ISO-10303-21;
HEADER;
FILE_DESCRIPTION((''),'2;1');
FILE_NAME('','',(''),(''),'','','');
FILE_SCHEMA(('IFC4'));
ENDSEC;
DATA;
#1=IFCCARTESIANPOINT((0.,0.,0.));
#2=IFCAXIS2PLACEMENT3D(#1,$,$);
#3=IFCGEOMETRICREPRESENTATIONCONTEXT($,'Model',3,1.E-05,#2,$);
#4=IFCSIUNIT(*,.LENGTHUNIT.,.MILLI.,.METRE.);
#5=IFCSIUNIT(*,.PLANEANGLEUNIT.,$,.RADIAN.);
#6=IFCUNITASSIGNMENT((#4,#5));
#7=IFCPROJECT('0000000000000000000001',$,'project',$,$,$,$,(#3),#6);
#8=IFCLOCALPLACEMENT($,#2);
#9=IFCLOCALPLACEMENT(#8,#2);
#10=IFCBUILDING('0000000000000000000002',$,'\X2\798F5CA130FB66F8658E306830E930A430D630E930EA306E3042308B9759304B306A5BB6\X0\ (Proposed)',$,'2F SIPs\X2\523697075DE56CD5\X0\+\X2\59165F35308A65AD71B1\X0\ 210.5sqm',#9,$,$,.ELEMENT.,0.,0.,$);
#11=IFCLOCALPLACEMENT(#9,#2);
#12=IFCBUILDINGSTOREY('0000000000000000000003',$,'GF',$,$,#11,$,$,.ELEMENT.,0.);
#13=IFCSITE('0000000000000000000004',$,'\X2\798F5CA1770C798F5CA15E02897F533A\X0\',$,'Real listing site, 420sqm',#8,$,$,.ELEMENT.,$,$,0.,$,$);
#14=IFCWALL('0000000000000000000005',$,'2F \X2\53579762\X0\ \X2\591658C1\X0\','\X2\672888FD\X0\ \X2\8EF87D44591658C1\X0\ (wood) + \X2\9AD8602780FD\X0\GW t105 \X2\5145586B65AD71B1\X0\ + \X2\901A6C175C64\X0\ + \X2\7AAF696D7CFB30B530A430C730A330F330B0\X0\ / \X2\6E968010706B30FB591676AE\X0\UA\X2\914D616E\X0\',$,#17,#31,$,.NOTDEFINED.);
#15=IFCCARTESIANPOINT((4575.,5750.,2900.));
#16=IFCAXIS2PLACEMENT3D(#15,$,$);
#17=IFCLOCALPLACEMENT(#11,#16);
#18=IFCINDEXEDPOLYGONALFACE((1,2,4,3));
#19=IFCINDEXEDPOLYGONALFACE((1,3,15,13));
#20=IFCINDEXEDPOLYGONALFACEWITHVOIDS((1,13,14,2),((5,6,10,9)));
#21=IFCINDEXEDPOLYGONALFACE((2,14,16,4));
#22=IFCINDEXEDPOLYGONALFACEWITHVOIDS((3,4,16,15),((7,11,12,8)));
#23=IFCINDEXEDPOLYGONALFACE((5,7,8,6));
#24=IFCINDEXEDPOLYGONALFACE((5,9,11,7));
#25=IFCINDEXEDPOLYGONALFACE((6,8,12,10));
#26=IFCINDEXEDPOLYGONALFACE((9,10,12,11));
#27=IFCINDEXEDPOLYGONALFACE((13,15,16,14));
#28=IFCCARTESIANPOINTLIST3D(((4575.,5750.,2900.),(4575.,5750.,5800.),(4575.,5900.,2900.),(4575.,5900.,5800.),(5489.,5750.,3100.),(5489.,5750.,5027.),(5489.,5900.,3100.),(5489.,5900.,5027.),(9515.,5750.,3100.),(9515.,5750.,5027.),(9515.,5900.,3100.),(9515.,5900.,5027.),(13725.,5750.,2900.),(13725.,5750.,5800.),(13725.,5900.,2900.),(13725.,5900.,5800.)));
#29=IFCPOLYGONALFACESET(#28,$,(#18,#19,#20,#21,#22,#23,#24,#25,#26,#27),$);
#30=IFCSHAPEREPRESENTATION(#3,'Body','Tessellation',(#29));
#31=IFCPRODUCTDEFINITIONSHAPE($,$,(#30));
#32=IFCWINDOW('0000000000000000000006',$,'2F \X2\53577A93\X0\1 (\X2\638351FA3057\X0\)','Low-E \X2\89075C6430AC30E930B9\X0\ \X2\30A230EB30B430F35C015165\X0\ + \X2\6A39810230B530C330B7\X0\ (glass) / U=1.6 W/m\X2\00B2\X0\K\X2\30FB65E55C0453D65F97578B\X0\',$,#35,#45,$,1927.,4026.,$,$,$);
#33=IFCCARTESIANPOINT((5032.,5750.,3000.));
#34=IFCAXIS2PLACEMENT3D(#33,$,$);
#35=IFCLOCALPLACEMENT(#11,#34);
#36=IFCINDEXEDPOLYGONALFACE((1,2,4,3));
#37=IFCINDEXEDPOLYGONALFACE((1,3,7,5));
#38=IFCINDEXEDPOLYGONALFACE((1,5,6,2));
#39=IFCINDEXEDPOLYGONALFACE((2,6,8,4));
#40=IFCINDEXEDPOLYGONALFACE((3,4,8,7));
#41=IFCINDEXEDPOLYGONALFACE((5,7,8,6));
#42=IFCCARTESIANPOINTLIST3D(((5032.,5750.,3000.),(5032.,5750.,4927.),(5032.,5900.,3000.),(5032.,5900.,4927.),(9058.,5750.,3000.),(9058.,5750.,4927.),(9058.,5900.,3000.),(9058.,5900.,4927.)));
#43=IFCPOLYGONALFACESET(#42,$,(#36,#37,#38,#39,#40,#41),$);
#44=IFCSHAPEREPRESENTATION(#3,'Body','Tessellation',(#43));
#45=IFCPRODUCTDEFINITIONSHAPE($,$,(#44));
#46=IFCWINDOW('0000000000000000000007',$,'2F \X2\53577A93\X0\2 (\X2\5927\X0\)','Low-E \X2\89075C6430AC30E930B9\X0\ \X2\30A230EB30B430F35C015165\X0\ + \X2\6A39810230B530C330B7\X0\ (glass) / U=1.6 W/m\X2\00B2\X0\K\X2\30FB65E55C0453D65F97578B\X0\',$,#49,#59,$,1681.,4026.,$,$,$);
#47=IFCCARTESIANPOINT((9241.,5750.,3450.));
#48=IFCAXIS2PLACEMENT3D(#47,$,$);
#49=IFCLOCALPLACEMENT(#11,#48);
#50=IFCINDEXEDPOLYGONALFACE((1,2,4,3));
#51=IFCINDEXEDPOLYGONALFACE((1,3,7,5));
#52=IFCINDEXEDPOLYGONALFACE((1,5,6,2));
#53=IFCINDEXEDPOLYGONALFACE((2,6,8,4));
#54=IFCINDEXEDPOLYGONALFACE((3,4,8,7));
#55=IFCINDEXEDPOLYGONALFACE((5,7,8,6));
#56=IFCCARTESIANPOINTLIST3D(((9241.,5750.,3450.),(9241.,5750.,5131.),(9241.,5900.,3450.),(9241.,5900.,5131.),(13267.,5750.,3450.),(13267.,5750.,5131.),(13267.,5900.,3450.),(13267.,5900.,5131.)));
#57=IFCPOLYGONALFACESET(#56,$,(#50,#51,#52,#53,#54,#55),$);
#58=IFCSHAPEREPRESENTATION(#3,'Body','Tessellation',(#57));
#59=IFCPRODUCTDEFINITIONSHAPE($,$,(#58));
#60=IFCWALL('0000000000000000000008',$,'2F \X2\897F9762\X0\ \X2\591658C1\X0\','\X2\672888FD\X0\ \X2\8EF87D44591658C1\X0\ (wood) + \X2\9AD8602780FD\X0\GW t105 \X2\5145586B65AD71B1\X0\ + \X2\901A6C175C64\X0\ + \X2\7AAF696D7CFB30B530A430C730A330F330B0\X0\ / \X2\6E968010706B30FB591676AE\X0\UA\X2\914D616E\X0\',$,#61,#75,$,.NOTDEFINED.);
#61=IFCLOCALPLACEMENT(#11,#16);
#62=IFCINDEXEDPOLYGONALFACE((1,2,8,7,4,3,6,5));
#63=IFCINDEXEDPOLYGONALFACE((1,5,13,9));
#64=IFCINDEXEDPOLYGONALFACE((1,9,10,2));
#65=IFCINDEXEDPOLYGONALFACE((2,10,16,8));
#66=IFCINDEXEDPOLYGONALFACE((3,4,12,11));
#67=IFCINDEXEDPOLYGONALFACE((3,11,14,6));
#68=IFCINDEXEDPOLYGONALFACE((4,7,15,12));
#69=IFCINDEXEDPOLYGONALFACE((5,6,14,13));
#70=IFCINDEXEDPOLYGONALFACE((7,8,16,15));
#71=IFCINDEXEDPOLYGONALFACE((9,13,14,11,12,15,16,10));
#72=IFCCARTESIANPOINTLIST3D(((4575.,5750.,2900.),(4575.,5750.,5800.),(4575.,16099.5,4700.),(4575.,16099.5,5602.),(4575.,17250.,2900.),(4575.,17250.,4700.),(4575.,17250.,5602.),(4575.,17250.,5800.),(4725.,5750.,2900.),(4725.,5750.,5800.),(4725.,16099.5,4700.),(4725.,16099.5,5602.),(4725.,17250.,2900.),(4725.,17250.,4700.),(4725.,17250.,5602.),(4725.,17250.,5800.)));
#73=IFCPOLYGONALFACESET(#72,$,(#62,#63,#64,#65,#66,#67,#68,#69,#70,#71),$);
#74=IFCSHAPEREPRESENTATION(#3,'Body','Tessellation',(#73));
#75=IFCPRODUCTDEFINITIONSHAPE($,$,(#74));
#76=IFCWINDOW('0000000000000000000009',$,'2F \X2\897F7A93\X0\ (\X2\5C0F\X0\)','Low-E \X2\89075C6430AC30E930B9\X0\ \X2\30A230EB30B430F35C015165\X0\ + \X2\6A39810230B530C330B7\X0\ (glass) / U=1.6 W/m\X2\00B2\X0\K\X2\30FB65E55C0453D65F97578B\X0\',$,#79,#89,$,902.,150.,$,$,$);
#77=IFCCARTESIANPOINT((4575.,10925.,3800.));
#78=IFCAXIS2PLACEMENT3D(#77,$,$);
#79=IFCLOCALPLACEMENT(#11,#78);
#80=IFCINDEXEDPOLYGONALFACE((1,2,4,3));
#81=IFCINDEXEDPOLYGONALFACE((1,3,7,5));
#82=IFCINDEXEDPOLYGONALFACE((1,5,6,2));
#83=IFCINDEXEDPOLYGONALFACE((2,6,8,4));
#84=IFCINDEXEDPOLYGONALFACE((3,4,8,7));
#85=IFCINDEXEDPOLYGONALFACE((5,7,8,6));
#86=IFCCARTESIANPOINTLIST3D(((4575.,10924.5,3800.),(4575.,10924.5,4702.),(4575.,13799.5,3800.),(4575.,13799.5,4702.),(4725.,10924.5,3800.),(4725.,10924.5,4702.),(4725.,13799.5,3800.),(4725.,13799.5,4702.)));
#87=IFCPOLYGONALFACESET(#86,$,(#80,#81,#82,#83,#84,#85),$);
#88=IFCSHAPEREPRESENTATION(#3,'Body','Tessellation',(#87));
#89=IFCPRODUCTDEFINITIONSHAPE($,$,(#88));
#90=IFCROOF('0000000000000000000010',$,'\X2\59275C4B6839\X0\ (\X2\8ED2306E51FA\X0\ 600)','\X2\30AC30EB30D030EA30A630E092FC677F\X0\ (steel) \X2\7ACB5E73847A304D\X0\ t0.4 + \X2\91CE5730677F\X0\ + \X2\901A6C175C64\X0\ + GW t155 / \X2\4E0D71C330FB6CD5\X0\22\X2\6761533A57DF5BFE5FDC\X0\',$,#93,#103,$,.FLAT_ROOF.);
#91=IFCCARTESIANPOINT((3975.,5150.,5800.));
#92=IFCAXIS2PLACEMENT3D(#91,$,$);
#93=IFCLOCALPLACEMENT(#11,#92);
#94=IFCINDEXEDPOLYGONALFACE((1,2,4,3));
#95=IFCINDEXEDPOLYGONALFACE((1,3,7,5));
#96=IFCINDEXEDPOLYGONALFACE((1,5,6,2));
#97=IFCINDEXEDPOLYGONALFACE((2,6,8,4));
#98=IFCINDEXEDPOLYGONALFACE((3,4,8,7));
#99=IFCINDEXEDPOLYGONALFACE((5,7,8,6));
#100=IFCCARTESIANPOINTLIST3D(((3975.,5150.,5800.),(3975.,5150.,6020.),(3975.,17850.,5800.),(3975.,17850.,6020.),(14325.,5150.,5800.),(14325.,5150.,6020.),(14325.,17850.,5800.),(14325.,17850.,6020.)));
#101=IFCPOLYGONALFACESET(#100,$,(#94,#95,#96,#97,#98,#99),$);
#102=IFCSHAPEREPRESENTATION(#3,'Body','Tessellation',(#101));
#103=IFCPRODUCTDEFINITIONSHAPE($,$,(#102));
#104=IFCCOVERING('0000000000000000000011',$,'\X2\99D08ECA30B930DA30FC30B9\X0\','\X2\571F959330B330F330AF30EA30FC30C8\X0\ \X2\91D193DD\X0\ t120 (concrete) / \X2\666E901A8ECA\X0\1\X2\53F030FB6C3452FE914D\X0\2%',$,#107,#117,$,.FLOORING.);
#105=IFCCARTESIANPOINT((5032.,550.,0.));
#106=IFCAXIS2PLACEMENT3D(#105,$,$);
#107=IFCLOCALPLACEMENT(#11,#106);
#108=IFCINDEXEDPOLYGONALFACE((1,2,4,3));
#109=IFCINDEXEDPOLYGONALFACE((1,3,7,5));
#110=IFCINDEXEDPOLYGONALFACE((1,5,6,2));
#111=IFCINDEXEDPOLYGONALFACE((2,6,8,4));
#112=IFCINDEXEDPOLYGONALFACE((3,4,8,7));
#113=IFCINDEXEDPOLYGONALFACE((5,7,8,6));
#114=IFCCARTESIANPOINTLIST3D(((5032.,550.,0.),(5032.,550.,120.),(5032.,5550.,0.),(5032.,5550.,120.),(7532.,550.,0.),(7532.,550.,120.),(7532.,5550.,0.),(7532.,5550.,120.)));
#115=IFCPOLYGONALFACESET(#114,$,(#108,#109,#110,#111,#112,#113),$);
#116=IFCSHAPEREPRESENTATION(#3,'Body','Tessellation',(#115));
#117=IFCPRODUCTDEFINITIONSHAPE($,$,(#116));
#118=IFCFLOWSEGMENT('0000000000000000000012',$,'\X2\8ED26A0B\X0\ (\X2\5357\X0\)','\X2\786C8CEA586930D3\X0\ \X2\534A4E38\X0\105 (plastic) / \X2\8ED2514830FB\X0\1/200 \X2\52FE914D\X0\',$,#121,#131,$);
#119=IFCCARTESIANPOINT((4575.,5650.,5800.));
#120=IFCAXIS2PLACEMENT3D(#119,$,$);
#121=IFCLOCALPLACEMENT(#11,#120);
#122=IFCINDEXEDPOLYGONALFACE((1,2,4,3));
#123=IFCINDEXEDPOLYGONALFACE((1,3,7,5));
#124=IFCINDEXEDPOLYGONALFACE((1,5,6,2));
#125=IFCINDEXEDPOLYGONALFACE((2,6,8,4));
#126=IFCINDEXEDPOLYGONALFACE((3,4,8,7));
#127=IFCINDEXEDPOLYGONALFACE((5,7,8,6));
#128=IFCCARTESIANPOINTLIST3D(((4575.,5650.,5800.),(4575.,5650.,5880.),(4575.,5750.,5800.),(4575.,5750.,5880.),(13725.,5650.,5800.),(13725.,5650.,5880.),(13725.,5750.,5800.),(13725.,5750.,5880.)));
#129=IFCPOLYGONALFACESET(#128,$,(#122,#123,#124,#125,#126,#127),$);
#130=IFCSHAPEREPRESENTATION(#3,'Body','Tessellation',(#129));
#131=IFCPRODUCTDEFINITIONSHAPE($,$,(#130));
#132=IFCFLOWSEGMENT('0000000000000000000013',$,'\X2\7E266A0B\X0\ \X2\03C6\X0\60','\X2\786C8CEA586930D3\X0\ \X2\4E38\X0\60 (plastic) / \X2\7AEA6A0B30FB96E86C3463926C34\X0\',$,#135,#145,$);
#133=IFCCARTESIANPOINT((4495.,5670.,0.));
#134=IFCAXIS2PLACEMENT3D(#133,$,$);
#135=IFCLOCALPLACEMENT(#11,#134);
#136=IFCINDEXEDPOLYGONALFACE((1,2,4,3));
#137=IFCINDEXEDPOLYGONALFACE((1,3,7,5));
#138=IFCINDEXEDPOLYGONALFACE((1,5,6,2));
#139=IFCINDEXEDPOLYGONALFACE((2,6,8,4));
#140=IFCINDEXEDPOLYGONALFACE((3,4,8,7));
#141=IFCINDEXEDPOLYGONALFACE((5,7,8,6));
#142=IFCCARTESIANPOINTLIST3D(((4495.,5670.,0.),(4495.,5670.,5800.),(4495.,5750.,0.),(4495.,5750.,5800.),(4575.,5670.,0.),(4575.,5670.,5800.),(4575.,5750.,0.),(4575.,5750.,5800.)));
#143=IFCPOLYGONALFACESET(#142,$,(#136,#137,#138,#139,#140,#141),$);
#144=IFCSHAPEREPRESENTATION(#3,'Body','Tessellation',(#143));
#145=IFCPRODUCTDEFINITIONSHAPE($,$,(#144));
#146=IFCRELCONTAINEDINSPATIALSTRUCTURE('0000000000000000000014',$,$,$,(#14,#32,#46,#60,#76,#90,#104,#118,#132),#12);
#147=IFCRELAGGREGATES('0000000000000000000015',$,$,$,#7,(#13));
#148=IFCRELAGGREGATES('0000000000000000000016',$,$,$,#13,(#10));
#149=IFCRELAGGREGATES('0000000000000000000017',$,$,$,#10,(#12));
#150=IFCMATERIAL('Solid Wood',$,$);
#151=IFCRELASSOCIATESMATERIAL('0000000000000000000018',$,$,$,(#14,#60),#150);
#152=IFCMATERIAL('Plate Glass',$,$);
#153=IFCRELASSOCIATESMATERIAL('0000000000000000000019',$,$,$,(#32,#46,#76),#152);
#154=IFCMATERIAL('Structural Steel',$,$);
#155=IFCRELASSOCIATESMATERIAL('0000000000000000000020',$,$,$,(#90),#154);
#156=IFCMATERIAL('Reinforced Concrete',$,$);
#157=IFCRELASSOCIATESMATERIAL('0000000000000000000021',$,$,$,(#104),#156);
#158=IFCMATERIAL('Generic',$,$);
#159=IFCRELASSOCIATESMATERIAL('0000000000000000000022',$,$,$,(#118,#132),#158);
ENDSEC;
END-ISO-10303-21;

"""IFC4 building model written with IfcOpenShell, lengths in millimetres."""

from ifc_helpers import new_model, si_unit, frame, frame_2d, origin, place, context, project, spatial, rectangle, extrude, material, element, fill, save


model = new_model("IFC4")

# Units and contexts
model_context = context("Model", 3, precision=1e-05, world=origin())
ifc_project = project(units=[si_unit("LENGTHUNIT", "METRE", prefix="MILLI"), si_unit("PLANEANGLEUNIT", "RADIAN")], contexts=[model_context])

# Site, building, storey
site_placement = place(None, origin())
site = spatial("IfcSite", under=ifc_project, at=site_placement, Name="福岡県福岡市西区", ObjectType="Real listing site, 420sqm", CompositionType="ELEMENT", RefElevation=0.0)
building_placement = place(site_placement, origin())
building = spatial("IfcBuilding", under=site, at=building_placement, Name="福岡・書斎とライブラリのある静かな家 (Proposed)", ObjectType="2F SIPs制震工法+外張り断熱 210.5sqm", CompositionType="ELEMENT", ElevationOfRefHeight=0.0, ElevationOfTerrain=0.0)
storey_placement = place(building_placement, origin())
storey = spatial("IfcBuildingStorey", under=building, at=storey_placement, Name="GF", CompositionType="ELEMENT", Elevation=0.0)

# Shared definitions
ifc_material_1 = material(Name="Solid Wood")

# Shared definitions
ifc_material_2 = material(Name="Reinforced Concrete")

# Shared definitions
ifc_material_3 = material(Name="Plate Glass")

# Wall, openings, windows
wall_1_placement = place(storey_placement, frame((4575.0, 5750.0, 2900.0)))
wall_1 = element("IfcWall", 1, at=wall_1_placement, inside=storey, material=ifc_material_1, Name="2F 南面 外壁", Description="木製 軸組外壁 (wood) + 高性能GW t105 充填断熱 + 通気層 + 窯業系サイディング / 準耐火・外皮UA配慮", PredefinedType="NOTDEFINED", context=model_context, shape_type="SweptSolid", body=[
    extrude(rectangle(XDim=9150.0, YDim=150.0, at=frame_2d((4575.0, 75.0))), frame((4575.0, 5750.0, 2900.0)), (0.0, 0.0, 1.0), 2900.0),
])
opening_1_placement = place(storey_placement, frame((5032.0, 5750.0, 3000.0)))
opening_1 = element("IfcOpeningElement", 2, at=opening_1_placement, cuts=wall_1, PredefinedType="NOTDEFINED", context=model_context, shape_type="SweptSolid", body=[
    extrude(rectangle(XDim=4026.0, YDim=150.0, at=frame_2d((2013.0, 75.0))), frame((5032.0, 5750.0, 3000.0)), (0.0, 0.0, 1.0), 1927.0),
])
opening_2_placement = place(storey_placement, frame((9241.0, 5750.0, 3450.0)))
opening_2 = element("IfcOpeningElement", 3, at=opening_2_placement, cuts=wall_1, PredefinedType="NOTDEFINED", context=model_context, shape_type="SweptSolid", body=[
    extrude(rectangle(XDim=4026.0, YDim=150.0, at=frame_2d((2013.0, 75.0))), frame((9241.0, 5750.0, 3450.0)), (0.0, 0.0, 1.0), 1681.0),
])
window_1_placement = place(storey_placement, frame((5032.0, 5750.0, 3000.0)))
window_1 = element("IfcWindow", 4, at=window_1_placement, inside=storey, material=ifc_material_3, Name="2F 南窓1 (掃出し)", Description="Low-E 複層ガラス アルゴン封入 + 樹脂サッシ (glass) / U=1.6 W/m²K・日射取得型", OverallHeight=1927.0, OverallWidth=4026.0, context=model_context, shape_type="SweptSolid", body=[
    extrude(rectangle(XDim=4026.0, YDim=150.0, at=frame_2d((2013.0, 75.0))), frame((5032.0, 5750.0, 3000.0)), (0.0, 0.0, 1.0), 1927.0),
])
fill(opening_1, window_1)
window_2_placement = place(storey_placement, frame((9241.0, 5750.0, 3450.0)))
window_2 = element("IfcWindow", 5, at=window_2_placement, inside=storey, material=ifc_material_3, Name="2F 南窓2 (大)", Description="Low-E 複層ガラス アルゴン封入 + 樹脂サッシ (glass) / U=1.6 W/m²K・日射取得型", OverallHeight=1681.0, OverallWidth=4026.0, context=model_context, shape_type="SweptSolid", body=[
    extrude(rectangle(XDim=4026.0, YDim=150.0, at=frame_2d((2013.0, 75.0))), frame((9241.0, 5750.0, 3450.0)), (0.0, 0.0, 1.0), 1681.0),
])
fill(opening_2, window_2)

# Wall, opening, window
wall_2_placement = place(storey_placement, frame((4575.0, 5750.0, 2900.0)))
wall_2 = element("IfcWall", 6, at=wall_2_placement, inside=storey, material=ifc_material_1, Name="2F 西面 外壁", Description="木製 軸組外壁 (wood) + 高性能GW t105 充填断熱 + 通気層 + 窯業系サイディング / 準耐火・外皮UA配慮", PredefinedType="NOTDEFINED", context=model_context, shape_type="SweptSolid", body=[
    extrude(rectangle(XDim=150.0, YDim=11500.0, at=frame_2d((75.0, 5750.0))), frame((4575.0, 5750.0, 2900.0)), (0.0, 0.0, 1.0), 2900.0),
])
opening_3_placement = place(storey_placement, frame((4575.0, 10925.0, 3800.0)))
opening_3 = element("IfcOpeningElement", 7, at=opening_3_placement, cuts=wall_2, PredefinedType="NOTDEFINED", context=model_context, shape_type="SweptSolid", body=[
    extrude(rectangle(XDim=150.0, YDim=2875.0, at=frame_2d((75.0, 1437.0))), frame((4575.0, 10925.0, 3800.0)), (0.0, 0.0, 1.0), 902.0),
])
window_3_placement = place(storey_placement, frame((4575.0, 10925.0, 3800.0)))
window_3 = element("IfcWindow", 8, at=window_3_placement, inside=storey, material=ifc_material_3, Name="2F 西窓 (小)", Description="Low-E 複層ガラス アルゴン封入 + 樹脂サッシ (glass) / U=1.6 W/m²K・日射取得型", OverallHeight=902.0, OverallWidth=150.0, context=model_context, shape_type="SweptSolid", body=[
    extrude(rectangle(XDim=150.0, YDim=2875.0, at=frame_2d((75.0, 1437.0))), frame((4575.0, 10925.0, 3800.0)), (0.0, 0.0, 1.0), 902.0),
])
fill(opening_3, window_3)

# Roof
ifc_material_4 = material(Name="Structural Steel")
roof_placement = place(storey_placement, frame((3975.0, 5150.0, 5800.0)))
element("IfcRoof", 9, at=roof_placement, inside=storey, material=ifc_material_4, Name="大屋根 (軒の出 600)", Description="ガルバリウム鋼板 (steel) 立平葺き t0.4 + 野地板 + 通気層 + GW t155 / 不燃・法22条区域対応", PredefinedType="FLAT_ROOF", context=model_context, shape_type="SweptSolid", body=[
    extrude(rectangle(XDim=10350.0, YDim=12700.0, at=frame_2d((5175.0, 6350.0))), frame((3975.0, 5150.0, 5800.0)), (0.0, 0.0, 1.0), 220.0),
])

# Covering
covering_placement = place(storey_placement, frame((5032.0, 550.0, 0.0)))
element("IfcCovering", 10, at=covering_placement, inside=storey, material=ifc_material_2, Name="駐車スペース", Description="土間コンクリート 金鏝 t120 (concrete) / 普通車1台・水勾配2%", PredefinedType="FLOORING", context=model_context, shape_type="SweptSolid", body=[
    extrude(rectangle(XDim=2500.0, YDim=5000.0, at=frame_2d((1250.0, 2500.0))), frame((5032.0, 550.0, 0.0)), (0.0, 0.0, 1.0), 120.0),
])

# Flow segments
ifc_material_5 = material(Name="Generic")
flow_segment_1_placement = place(storey_placement, frame((4575.0, 5650.0, 5800.0)))
element("IfcFlowSegment", 11, at=flow_segment_1_placement, inside=storey, material=ifc_material_5, Name="軒樋 (南)", Description="硬質塩ビ 半丸105 (plastic) / 軒先・1/200 勾配", context=model_context, shape_type="SweptSolid", body=[
    extrude(rectangle(XDim=9150.0, YDim=100.0, at=frame_2d((4575.0, 50.0))), frame((4575.0, 5650.0, 5800.0)), (0.0, 0.0, 1.0), 80.0),
])
flow_segment_2_placement = place(storey_placement, frame((4495.0, 5670.0, 0.0)))
element("IfcFlowSegment", 12, at=flow_segment_2_placement, inside=storey, material=ifc_material_5, Name="縦樋 φ60", Description="硬質塩ビ 丸60 (plastic) / 竪樋・雨水排水", context=model_context, shape_type="SweptSolid", body=[
    extrude(rectangle(XDim=80.0, YDim=80.0, at=frame_2d((40.0, 40.0))), frame((4495.0, 5670.0, 0.0)), (0.0, 0.0, 1.0), 5800.0),
])

save(model, "model.ifc")
